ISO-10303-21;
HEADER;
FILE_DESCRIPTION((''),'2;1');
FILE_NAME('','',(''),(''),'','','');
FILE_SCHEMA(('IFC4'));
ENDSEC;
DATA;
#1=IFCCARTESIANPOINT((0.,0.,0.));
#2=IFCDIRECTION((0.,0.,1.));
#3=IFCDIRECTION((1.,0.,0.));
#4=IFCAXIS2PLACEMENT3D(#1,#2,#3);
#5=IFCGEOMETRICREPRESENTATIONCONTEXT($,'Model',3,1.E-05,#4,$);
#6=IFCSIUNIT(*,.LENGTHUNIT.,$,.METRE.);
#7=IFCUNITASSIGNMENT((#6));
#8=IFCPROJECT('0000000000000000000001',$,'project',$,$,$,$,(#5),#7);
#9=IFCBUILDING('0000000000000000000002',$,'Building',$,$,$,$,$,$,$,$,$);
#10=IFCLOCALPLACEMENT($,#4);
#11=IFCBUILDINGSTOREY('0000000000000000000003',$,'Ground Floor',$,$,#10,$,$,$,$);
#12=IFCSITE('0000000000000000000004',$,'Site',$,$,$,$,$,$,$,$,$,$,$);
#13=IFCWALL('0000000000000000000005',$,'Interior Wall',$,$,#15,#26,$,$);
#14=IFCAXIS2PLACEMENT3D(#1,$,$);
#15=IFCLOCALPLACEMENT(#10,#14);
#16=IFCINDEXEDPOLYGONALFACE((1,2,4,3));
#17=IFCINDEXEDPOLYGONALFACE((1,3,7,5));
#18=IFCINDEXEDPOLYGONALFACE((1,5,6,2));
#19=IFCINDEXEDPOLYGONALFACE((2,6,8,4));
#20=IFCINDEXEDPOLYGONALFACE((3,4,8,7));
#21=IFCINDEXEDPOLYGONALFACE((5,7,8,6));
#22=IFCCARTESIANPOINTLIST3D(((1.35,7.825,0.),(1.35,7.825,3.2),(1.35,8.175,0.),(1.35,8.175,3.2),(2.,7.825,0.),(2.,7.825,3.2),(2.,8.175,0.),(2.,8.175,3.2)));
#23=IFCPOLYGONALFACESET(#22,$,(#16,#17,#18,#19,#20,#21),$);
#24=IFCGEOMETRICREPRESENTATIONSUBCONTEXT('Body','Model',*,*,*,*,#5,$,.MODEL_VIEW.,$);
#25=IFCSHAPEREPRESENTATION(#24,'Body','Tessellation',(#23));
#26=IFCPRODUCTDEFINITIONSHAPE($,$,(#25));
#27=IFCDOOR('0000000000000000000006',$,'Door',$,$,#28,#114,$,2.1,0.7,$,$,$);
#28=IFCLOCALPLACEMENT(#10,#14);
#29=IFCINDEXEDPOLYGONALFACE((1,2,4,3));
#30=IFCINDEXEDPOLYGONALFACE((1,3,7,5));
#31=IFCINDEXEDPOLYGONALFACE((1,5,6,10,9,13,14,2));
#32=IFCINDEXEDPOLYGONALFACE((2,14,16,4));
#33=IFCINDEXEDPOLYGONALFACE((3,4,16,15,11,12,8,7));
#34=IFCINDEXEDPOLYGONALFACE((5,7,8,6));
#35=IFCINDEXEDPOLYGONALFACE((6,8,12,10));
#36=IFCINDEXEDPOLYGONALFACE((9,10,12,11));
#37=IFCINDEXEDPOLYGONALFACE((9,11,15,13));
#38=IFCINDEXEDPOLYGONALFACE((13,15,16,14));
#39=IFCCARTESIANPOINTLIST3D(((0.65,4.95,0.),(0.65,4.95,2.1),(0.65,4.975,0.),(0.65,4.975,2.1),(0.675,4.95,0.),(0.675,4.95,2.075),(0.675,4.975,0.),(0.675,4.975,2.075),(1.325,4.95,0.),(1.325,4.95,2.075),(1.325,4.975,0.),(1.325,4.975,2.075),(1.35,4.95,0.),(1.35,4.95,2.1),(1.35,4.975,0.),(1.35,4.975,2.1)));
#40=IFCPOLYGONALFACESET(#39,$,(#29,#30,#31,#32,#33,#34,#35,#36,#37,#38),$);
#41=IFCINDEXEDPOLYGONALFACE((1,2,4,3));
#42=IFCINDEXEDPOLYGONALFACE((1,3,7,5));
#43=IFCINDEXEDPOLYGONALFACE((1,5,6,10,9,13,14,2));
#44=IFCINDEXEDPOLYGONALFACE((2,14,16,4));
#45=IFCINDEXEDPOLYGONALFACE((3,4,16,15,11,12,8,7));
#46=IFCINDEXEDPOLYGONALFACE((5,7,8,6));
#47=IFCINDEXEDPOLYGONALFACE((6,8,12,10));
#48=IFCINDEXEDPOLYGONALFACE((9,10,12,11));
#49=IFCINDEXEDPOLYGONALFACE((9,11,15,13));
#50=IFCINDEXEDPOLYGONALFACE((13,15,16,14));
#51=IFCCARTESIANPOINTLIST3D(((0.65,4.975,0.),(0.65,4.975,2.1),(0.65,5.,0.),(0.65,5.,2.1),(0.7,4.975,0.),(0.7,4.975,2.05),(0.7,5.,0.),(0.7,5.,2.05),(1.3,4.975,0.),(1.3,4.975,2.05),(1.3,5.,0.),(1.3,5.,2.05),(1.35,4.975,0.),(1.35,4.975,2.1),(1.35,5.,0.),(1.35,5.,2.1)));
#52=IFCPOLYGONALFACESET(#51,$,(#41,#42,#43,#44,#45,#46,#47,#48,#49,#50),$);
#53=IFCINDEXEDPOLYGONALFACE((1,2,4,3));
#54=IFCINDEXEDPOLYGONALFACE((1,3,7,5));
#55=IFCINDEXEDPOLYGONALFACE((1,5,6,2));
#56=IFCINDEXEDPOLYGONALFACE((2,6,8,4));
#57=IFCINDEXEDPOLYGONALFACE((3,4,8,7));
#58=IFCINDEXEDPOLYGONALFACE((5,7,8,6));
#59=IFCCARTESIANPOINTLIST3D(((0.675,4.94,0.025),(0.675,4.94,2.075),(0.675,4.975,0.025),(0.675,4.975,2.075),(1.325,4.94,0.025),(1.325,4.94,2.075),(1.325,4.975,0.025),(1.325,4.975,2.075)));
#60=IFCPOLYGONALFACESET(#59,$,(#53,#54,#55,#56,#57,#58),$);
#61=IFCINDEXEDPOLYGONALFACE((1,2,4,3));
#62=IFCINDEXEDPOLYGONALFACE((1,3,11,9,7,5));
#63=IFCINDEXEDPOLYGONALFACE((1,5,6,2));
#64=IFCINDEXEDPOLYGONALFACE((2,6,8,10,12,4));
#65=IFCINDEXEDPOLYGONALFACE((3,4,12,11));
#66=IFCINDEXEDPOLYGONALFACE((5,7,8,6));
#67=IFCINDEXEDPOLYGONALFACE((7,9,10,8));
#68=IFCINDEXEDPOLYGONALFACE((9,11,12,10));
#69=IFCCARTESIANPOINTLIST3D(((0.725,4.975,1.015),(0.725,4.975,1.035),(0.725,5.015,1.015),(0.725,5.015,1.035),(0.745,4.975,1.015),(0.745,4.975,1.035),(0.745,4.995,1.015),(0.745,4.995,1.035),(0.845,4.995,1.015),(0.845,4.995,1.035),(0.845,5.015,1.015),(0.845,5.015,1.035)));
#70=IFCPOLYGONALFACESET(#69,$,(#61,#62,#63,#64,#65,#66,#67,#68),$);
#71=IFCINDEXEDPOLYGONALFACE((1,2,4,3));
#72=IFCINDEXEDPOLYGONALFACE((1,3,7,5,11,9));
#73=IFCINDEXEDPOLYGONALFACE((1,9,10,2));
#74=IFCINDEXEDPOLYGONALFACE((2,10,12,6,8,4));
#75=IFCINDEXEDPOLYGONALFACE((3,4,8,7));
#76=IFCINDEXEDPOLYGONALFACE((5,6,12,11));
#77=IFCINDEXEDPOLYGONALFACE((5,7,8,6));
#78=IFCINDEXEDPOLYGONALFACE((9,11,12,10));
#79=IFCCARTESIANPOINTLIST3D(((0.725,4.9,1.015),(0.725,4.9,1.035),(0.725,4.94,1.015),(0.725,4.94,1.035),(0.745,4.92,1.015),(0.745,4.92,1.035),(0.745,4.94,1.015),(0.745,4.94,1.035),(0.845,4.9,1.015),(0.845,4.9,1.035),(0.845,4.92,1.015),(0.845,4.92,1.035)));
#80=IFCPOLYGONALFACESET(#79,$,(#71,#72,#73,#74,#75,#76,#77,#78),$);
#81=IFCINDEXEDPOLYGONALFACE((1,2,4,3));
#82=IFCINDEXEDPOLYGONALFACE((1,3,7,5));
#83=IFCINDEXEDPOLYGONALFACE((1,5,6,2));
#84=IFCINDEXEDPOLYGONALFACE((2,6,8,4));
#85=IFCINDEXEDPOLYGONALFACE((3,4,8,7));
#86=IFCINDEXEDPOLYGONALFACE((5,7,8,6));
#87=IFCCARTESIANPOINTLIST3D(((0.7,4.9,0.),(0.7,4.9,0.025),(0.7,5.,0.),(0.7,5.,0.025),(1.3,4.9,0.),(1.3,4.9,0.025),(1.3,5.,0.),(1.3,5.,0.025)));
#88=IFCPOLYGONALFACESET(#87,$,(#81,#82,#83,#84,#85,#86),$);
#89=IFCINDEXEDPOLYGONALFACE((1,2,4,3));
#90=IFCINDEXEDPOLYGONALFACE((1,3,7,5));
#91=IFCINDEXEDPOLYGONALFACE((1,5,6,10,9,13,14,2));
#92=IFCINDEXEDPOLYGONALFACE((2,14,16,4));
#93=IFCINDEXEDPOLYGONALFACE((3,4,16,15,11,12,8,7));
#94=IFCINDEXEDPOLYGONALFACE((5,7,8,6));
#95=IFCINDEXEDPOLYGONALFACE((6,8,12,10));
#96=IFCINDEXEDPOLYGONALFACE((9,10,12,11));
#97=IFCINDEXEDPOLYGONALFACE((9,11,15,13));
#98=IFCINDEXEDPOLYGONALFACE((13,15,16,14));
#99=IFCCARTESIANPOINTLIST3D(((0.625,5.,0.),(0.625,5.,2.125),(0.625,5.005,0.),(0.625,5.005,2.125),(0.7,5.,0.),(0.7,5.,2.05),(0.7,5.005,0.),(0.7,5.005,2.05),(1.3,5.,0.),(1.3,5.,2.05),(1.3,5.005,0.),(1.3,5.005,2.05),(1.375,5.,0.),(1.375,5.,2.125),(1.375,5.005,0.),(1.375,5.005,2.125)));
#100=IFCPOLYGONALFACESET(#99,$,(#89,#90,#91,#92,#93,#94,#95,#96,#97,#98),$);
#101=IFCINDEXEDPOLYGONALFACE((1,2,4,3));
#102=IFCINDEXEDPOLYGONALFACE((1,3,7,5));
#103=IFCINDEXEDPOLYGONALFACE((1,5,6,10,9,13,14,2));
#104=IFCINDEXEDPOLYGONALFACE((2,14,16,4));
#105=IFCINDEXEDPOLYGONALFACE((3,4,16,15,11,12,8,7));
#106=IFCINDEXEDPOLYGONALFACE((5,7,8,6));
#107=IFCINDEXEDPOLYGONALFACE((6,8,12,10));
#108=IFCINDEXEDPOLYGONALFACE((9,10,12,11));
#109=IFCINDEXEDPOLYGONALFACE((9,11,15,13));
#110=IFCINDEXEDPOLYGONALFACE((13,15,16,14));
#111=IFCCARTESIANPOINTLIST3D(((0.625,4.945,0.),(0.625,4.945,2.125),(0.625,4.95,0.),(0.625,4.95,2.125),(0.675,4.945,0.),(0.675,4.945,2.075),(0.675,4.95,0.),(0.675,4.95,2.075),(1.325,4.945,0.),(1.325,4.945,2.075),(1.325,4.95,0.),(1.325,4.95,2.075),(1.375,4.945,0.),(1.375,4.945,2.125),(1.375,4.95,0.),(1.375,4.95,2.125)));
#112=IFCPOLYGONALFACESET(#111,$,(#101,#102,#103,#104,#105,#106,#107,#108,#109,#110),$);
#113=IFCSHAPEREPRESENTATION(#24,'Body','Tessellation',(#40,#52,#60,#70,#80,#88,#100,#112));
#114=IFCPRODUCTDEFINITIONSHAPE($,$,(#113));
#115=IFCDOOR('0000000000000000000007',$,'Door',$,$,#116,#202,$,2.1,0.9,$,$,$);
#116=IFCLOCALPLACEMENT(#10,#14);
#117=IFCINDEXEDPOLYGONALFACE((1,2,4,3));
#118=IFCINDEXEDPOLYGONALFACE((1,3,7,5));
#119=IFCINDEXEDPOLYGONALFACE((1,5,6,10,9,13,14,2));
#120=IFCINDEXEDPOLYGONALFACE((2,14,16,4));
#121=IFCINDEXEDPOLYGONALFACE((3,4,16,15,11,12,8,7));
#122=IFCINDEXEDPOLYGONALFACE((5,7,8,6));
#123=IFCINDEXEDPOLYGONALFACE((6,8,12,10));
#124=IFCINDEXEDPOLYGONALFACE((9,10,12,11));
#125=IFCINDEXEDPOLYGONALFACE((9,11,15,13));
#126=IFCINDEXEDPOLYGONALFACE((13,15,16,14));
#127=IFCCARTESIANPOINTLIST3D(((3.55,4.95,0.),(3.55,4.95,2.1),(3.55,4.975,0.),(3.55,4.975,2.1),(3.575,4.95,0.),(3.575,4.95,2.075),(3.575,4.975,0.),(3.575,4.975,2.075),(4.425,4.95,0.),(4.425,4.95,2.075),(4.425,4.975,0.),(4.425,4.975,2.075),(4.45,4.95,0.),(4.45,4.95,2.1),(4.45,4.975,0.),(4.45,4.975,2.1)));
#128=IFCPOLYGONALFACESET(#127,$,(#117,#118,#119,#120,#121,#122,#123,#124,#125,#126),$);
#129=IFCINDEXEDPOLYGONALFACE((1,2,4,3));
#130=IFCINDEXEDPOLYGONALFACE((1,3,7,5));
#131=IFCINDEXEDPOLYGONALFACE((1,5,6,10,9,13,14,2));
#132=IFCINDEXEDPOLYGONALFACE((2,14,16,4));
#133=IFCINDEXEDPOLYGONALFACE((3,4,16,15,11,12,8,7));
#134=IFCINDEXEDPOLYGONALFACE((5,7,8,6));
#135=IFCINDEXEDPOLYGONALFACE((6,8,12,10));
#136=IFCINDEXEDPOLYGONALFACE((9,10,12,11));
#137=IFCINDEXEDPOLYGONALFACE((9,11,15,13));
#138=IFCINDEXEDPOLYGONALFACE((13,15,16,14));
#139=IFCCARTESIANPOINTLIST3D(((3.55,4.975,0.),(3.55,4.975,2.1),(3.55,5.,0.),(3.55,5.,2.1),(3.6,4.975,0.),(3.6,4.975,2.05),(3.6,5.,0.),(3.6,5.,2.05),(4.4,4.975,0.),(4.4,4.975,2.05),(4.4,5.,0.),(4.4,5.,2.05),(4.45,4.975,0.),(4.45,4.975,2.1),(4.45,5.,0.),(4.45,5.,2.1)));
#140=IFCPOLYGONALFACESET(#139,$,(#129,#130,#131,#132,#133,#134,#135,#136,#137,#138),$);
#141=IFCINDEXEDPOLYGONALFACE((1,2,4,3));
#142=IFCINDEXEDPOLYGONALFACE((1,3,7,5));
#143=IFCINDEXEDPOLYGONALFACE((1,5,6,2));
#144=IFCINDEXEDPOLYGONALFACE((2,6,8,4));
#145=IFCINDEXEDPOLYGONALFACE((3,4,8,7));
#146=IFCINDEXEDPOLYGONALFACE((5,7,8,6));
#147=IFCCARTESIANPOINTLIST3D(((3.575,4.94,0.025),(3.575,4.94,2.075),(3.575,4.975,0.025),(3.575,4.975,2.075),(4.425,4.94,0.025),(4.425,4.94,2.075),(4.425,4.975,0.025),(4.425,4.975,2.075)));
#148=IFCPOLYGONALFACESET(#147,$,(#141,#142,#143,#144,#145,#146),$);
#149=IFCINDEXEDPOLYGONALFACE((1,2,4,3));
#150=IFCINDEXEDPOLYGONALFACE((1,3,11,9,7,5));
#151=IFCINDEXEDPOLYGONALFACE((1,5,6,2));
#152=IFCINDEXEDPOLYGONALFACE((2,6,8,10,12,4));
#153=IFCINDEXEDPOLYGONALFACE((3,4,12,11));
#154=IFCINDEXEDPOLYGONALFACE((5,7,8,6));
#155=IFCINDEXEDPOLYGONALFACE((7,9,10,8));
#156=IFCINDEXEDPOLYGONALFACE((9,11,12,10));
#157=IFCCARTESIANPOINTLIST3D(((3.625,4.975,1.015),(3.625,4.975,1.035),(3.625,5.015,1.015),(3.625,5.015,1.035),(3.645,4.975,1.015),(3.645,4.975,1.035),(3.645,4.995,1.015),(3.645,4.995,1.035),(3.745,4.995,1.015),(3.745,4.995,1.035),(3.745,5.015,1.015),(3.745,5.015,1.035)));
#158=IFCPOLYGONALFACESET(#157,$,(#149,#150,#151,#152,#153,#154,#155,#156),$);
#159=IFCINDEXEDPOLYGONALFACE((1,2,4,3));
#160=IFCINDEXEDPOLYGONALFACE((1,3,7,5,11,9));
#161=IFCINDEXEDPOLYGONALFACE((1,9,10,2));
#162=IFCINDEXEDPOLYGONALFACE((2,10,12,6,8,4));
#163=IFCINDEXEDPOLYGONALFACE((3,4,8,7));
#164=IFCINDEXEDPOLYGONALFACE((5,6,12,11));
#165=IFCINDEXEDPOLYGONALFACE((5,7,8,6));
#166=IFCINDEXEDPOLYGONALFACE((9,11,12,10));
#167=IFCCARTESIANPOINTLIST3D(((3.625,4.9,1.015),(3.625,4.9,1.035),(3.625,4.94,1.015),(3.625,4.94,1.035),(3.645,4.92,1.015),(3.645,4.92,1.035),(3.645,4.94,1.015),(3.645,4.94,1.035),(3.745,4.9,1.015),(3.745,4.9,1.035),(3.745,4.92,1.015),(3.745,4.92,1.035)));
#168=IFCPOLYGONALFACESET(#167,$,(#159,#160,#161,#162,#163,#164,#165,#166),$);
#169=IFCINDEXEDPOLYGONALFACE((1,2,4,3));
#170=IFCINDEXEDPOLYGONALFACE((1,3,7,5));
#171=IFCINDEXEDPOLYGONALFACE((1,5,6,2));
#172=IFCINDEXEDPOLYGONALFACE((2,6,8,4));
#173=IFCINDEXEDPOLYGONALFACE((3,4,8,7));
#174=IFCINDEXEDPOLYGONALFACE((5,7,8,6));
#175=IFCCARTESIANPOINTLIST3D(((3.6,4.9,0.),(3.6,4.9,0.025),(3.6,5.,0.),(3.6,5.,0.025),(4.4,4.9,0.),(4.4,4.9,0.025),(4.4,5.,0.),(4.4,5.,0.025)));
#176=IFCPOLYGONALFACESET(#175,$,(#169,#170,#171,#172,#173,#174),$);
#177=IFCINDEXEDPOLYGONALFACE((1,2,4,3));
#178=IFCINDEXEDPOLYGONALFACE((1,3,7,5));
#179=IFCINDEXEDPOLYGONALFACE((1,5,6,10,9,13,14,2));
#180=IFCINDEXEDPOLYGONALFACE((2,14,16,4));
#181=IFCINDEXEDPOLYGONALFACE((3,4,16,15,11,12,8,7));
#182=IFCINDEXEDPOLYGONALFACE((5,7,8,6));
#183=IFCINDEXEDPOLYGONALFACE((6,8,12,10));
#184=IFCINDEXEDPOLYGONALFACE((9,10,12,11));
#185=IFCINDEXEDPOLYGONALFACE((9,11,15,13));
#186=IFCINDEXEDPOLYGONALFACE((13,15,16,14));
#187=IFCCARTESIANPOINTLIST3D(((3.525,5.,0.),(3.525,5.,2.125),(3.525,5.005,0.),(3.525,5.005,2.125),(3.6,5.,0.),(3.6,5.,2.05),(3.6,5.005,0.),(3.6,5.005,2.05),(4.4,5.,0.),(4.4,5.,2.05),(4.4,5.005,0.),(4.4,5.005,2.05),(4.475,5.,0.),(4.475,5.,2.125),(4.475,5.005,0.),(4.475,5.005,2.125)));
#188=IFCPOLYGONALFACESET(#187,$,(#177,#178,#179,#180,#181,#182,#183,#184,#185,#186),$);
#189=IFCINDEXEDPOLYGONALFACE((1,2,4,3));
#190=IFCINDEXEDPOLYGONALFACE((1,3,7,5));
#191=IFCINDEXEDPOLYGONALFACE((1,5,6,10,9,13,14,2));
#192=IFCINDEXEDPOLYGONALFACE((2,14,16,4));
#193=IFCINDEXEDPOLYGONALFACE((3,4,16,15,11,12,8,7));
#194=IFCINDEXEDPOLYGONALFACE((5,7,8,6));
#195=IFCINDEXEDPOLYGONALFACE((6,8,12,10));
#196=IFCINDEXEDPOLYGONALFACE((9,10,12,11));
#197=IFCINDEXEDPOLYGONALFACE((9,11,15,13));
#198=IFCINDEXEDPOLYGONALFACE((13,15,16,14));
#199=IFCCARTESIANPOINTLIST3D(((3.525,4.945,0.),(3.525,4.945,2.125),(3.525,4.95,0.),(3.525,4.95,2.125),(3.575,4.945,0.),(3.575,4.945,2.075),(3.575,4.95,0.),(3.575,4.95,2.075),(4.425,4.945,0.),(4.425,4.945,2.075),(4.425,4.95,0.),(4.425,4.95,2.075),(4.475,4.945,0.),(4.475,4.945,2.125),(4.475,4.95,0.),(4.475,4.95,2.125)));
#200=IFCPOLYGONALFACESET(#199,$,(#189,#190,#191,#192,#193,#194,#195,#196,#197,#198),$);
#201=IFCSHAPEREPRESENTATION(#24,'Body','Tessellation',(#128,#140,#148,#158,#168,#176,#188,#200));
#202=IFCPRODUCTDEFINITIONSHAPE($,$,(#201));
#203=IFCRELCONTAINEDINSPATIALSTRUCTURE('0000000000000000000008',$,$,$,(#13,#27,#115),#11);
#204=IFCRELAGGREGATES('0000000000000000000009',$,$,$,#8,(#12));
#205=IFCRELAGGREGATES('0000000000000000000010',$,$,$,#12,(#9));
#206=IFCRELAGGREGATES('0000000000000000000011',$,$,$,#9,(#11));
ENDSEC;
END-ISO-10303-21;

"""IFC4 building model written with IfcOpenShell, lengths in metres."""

from ifc_helpers import new_model, si_unit, frame, origin_with_axes, place, context, subcontext, project, spatial, line, indexed_curve, outline, extrude, element, save


model = new_model("IFC4")

# Units and contexts
model_context = context("Model", 3, precision=1e-05, world=origin_with_axes())
body_context = subcontext(model_context, "Body", "Model", "MODEL_VIEW")
ifc_project = project(units=[si_unit("LENGTHUNIT", "METRE")], contexts=[model_context])

# Site, building, storey
site = spatial("IfcSite", under=ifc_project, Name="Site")
building = spatial("IfcBuilding", under=site, Name="Building")
storey_placement = place(None, origin_with_axes())
storey = spatial("IfcBuildingStorey", under=building, at=storey_placement, Name="Ground Floor")

# Wall
wall_1_placement = place(storey_placement, frame((1.35, 8.0, 0.0), z_axis=(0.0, 0.0, 1.0), x_axis=(1.0, 0.0, 0.0)))
element("IfcWall", 1, at=wall_1_placement, inside=storey, Name="Interior Wall", context=body_context, shape_type="SweptSolid", body=[
    extrude(outline(indexed_curve([(0.0, 0.0), (0.0, 0.35), (0.65, 0.35), (0.65, 0.0), (0.0, 0.0)], self_intersect=False)), frame((0.0, -0.175, 0.0), z_axis=(0.0, 0.0, 1.0), x_axis=(1.0, 0.0, 0.0)), (0.0, 0.0, 1.0), 3.2),
])

# Doors
door_1_placement = place(storey_placement, frame((1.35, 5.0, 0.0), z_axis=(0.0, 0.0, 1.0), x_axis=(-1.0, 0.0, 0.0)))
element("IfcDoor", 2, at=door_1_placement, inside=storey, Name="Door", OverallHeight=2.1, OverallWidth=0.7, context=body_context, shape_type="SweptSolid", body=[
    extrude(outline(indexed_curve([(0.0, 0.0), (0.0, 2.1), (0.7, 2.1), (0.7, 0.0), (0.675, 0.0), (0.675, 2.075), (0.025, 2.075), (0.025, 0.0)], segments=[line(1, 2, 3, 4, 5, 6, 7, 8, 1)])), frame((0.0, 0.025, 0.0), z_axis=(0.0, -1.0, 0.0), x_axis=(1.0, 0.0, 0.0)), (0.0, 0.0, -1.0), 0.025),
    extrude(outline(indexed_curve([(0.0, 0.0), (0.0, 2.1), (0.7, 2.1), (0.7, 0.0), (0.65, 0.0), (0.65, 2.05), (0.05, 2.05), (0.05, 0.0)], segments=[line(1, 2, 3, 4, 5, 6, 7, 8, 1)])), frame((0.0, 0.0, 0.0), z_axis=(0.0, -1.0, 0.0), x_axis=(1.0, 0.0, 0.0)), (0.0, 0.0, -1.0), 0.025),
    extrude(outline(indexed_curve([(0.0, 0.0), (0.65, 0.0), (0.65, 0.035), (0.0, 0.035)], segments=[line(1, 2, 3, 4, 1)])), frame((0.025, 0.025, 0.025), z_axis=(0.0, 0.0, 1.0), x_axis=(1.0, 0.0, 0.0)), (0.0, 0.0, 1.0), 2.05),
    extrude(outline(indexed_curve([(0.0, 0.0), (0.0, -0.04), (-0.12, -0.04), (-0.12, -0.02), (-0.02, -0.02), (-0.02, 0.0)], segments=[line(1, 2, 3, 4, 5, 6, 1)])), frame((0.625, 0.025, 1.015), z_axis=(0.0, 0.0, 1.0), x_axis=(1.0, 0.0, 0.0)), (0.0, 0.0, 1.0), 0.02),
    extrude(outline(indexed_curve([(0.0, 0.0), (0.0, 0.04), (-0.12, 0.04), (-0.12, 0.02), (-0.02, 0.02), (-0.02, 0.0)], segments=[line(1, 2, 3, 4, 5, 6, 1)])), frame((0.625, 0.06, 1.015), z_axis=(0.0, 0.0, 1.0), x_axis=(1.0, 0.0, 0.0)), (0.0, 0.0, 1.0), 0.02),
    extrude(outline(indexed_curve([(0.0, 0.0), (0.6, 0.0), (0.6, 0.1), (0.0, 0.1)], segments=[line(1, 2, 3, 4, 1)])), frame((0.05, 0.0, 0.0), z_axis=(0.0, 0.0, 1.0), x_axis=(1.0, 0.0, 0.0)), (0.0, 0.0, 1.0), 0.025),
    extrude(outline(indexed_curve([(0.0, 0.0), (0.0, 2.125), (0.75, 2.125), (0.75, 0.0), (0.675, 0.0), (0.675, 2.05), (0.075, 2.05), (0.075, 0.0)], segments=[line(1, 2, 3, 4, 5, 6, 7, 8, 1)])), frame((-0.025, -0.005, 0.0), z_axis=(0.0, -1.0, 0.0), x_axis=(1.0, 0.0, 0.0)), (0.0, 0.0, -1.0), 0.005),
    extrude(outline(indexed_curve([(0.0, 0.0), (0.0, 2.125), (0.75, 2.125), (0.75, 0.0), (0.7, 0.0), (0.7, 2.075), (0.05, 2.075), (0.05, 0.0)], segments=[line(1, 2, 3, 4, 5, 6, 7, 8, 1)])), frame((-0.025, 0.05, 0.0), z_axis=(0.0, -1.0, 0.0), x_axis=(1.0, 0.0, 0.0)), (0.0, 0.0, -1.0), 0.005),
])
door_2_placement = place(storey_placement, frame((4.45, 5.0, 0.0), z_axis=(0.0, 0.0, 1.0), x_axis=(-1.0, 0.0, 0.0)))
element("IfcDoor", 3, at=door_2_placement, inside=storey, Name="Door", OverallHeight=2.1, OverallWidth=0.9, context=body_context, shape_type="SweptSolid", body=[
    extrude(outline(indexed_curve([(0.0, 0.0), (0.0, 2.1), (0.9, 2.1), (0.9, 0.0), (0.875, 0.0), (0.875, 2.075), (0.025, 2.075), (0.025, 0.0)], segments=[line(1, 2, 3, 4, 5, 6, 7, 8, 1)])), frame((0.0, 0.025, 0.0), z_axis=(0.0, -1.0, 0.0), x_axis=(1.0, 0.0, 0.0)), (0.0, 0.0, -1.0), 0.025),
    extrude(outline(indexed_curve([(0.0, 0.0), (0.0, 2.1), (0.9, 2.1), (0.9, 0.0), (0.85, 0.0), (0.85, 2.05), (0.05, 2.05), (0.05, 0.0)], segments=[line(1, 2, 3, 4, 5, 6, 7, 8, 1)])), frame((0.0, 0.0, 0.0), z_axis=(0.0, -1.0, 0.0), x_axis=(1.0, 0.0, 0.0)), (0.0, 0.0, -1.0), 0.025),
    extrude(outline(indexed_curve([(0.0, 0.0), (0.85, 0.0), (0.85, 0.035), (0.0, 0.035)], segments=[line(1, 2, 3, 4, 1)])), frame((0.025, 0.025, 0.025), z_axis=(0.0, 0.0, 1.0), x_axis=(1.0, 0.0, 0.0)), (0.0, 0.0, 1.0), 2.05),
    extrude(outline(indexed_curve([(0.0, 0.0), (0.0, -0.04), (-0.12, -0.04), (-0.12, -0.02), (-0.02, -0.02), (-0.02, 0.0)], segments=[line(1, 2, 3, 4, 5, 6, 1)])), frame((0.825, 0.025, 1.015), z_axis=(0.0, 0.0, 1.0), x_axis=(1.0, 0.0, 0.0)), (0.0, 0.0, 1.0), 0.02),
    extrude(outline(indexed_curve([(0.0, 0.0), (0.0, 0.04), (-0.12, 0.04), (-0.12, 0.02), (-0.02, 0.02), (-0.02, 0.0)], segments=[line(1, 2, 3, 4, 5, 6, 1)])), frame((0.825, 0.06, 1.015), z_axis=(0.0, 0.0, 1.0), x_axis=(1.0, 0.0, 0.0)), (0.0, 0.0, 1.0), 0.02),
    extrude(outline(indexed_curve([(0.0, 0.0), (0.8, 0.0), (0.8, 0.1), (0.0, 0.1)], segments=[line(1, 2, 3, 4, 1)])), frame((0.05, 0.0, 0.0), z_axis=(0.0, 0.0, 1.0), x_axis=(1.0, 0.0, 0.0)), (0.0, 0.0, 1.0), 0.025),
    extrude(outline(indexed_curve([(0.0, 0.0), (0.0, 2.125), (0.95, 2.125), (0.95, 0.0), (0.875, 0.0), (0.875, 2.05), (0.075, 2.05), (0.075, 0.0)], segments=[line(1, 2, 3, 4, 5, 6, 7, 8, 1)])), frame((-0.025, -0.005, 0.0), z_axis=(0.0, -1.0, 0.0), x_axis=(1.0, 0.0, 0.0)), (0.0, 0.0, -1.0), 0.005),
    extrude(outline(indexed_curve([(0.0, 0.0), (0.0, 2.125), (0.95, 2.125), (0.95, 0.0), (0.9, 0.0), (0.9, 2.075), (0.05, 2.075), (0.05, 0.0)], segments=[line(1, 2, 3, 4, 5, 6, 7, 8, 1)])), frame((-0.025, 0.05, 0.0), z_axis=(0.0, -1.0, 0.0), x_axis=(1.0, 0.0, 0.0)), (0.0, 0.0, -1.0), 0.005),
])

save(model, "model.ifc")
